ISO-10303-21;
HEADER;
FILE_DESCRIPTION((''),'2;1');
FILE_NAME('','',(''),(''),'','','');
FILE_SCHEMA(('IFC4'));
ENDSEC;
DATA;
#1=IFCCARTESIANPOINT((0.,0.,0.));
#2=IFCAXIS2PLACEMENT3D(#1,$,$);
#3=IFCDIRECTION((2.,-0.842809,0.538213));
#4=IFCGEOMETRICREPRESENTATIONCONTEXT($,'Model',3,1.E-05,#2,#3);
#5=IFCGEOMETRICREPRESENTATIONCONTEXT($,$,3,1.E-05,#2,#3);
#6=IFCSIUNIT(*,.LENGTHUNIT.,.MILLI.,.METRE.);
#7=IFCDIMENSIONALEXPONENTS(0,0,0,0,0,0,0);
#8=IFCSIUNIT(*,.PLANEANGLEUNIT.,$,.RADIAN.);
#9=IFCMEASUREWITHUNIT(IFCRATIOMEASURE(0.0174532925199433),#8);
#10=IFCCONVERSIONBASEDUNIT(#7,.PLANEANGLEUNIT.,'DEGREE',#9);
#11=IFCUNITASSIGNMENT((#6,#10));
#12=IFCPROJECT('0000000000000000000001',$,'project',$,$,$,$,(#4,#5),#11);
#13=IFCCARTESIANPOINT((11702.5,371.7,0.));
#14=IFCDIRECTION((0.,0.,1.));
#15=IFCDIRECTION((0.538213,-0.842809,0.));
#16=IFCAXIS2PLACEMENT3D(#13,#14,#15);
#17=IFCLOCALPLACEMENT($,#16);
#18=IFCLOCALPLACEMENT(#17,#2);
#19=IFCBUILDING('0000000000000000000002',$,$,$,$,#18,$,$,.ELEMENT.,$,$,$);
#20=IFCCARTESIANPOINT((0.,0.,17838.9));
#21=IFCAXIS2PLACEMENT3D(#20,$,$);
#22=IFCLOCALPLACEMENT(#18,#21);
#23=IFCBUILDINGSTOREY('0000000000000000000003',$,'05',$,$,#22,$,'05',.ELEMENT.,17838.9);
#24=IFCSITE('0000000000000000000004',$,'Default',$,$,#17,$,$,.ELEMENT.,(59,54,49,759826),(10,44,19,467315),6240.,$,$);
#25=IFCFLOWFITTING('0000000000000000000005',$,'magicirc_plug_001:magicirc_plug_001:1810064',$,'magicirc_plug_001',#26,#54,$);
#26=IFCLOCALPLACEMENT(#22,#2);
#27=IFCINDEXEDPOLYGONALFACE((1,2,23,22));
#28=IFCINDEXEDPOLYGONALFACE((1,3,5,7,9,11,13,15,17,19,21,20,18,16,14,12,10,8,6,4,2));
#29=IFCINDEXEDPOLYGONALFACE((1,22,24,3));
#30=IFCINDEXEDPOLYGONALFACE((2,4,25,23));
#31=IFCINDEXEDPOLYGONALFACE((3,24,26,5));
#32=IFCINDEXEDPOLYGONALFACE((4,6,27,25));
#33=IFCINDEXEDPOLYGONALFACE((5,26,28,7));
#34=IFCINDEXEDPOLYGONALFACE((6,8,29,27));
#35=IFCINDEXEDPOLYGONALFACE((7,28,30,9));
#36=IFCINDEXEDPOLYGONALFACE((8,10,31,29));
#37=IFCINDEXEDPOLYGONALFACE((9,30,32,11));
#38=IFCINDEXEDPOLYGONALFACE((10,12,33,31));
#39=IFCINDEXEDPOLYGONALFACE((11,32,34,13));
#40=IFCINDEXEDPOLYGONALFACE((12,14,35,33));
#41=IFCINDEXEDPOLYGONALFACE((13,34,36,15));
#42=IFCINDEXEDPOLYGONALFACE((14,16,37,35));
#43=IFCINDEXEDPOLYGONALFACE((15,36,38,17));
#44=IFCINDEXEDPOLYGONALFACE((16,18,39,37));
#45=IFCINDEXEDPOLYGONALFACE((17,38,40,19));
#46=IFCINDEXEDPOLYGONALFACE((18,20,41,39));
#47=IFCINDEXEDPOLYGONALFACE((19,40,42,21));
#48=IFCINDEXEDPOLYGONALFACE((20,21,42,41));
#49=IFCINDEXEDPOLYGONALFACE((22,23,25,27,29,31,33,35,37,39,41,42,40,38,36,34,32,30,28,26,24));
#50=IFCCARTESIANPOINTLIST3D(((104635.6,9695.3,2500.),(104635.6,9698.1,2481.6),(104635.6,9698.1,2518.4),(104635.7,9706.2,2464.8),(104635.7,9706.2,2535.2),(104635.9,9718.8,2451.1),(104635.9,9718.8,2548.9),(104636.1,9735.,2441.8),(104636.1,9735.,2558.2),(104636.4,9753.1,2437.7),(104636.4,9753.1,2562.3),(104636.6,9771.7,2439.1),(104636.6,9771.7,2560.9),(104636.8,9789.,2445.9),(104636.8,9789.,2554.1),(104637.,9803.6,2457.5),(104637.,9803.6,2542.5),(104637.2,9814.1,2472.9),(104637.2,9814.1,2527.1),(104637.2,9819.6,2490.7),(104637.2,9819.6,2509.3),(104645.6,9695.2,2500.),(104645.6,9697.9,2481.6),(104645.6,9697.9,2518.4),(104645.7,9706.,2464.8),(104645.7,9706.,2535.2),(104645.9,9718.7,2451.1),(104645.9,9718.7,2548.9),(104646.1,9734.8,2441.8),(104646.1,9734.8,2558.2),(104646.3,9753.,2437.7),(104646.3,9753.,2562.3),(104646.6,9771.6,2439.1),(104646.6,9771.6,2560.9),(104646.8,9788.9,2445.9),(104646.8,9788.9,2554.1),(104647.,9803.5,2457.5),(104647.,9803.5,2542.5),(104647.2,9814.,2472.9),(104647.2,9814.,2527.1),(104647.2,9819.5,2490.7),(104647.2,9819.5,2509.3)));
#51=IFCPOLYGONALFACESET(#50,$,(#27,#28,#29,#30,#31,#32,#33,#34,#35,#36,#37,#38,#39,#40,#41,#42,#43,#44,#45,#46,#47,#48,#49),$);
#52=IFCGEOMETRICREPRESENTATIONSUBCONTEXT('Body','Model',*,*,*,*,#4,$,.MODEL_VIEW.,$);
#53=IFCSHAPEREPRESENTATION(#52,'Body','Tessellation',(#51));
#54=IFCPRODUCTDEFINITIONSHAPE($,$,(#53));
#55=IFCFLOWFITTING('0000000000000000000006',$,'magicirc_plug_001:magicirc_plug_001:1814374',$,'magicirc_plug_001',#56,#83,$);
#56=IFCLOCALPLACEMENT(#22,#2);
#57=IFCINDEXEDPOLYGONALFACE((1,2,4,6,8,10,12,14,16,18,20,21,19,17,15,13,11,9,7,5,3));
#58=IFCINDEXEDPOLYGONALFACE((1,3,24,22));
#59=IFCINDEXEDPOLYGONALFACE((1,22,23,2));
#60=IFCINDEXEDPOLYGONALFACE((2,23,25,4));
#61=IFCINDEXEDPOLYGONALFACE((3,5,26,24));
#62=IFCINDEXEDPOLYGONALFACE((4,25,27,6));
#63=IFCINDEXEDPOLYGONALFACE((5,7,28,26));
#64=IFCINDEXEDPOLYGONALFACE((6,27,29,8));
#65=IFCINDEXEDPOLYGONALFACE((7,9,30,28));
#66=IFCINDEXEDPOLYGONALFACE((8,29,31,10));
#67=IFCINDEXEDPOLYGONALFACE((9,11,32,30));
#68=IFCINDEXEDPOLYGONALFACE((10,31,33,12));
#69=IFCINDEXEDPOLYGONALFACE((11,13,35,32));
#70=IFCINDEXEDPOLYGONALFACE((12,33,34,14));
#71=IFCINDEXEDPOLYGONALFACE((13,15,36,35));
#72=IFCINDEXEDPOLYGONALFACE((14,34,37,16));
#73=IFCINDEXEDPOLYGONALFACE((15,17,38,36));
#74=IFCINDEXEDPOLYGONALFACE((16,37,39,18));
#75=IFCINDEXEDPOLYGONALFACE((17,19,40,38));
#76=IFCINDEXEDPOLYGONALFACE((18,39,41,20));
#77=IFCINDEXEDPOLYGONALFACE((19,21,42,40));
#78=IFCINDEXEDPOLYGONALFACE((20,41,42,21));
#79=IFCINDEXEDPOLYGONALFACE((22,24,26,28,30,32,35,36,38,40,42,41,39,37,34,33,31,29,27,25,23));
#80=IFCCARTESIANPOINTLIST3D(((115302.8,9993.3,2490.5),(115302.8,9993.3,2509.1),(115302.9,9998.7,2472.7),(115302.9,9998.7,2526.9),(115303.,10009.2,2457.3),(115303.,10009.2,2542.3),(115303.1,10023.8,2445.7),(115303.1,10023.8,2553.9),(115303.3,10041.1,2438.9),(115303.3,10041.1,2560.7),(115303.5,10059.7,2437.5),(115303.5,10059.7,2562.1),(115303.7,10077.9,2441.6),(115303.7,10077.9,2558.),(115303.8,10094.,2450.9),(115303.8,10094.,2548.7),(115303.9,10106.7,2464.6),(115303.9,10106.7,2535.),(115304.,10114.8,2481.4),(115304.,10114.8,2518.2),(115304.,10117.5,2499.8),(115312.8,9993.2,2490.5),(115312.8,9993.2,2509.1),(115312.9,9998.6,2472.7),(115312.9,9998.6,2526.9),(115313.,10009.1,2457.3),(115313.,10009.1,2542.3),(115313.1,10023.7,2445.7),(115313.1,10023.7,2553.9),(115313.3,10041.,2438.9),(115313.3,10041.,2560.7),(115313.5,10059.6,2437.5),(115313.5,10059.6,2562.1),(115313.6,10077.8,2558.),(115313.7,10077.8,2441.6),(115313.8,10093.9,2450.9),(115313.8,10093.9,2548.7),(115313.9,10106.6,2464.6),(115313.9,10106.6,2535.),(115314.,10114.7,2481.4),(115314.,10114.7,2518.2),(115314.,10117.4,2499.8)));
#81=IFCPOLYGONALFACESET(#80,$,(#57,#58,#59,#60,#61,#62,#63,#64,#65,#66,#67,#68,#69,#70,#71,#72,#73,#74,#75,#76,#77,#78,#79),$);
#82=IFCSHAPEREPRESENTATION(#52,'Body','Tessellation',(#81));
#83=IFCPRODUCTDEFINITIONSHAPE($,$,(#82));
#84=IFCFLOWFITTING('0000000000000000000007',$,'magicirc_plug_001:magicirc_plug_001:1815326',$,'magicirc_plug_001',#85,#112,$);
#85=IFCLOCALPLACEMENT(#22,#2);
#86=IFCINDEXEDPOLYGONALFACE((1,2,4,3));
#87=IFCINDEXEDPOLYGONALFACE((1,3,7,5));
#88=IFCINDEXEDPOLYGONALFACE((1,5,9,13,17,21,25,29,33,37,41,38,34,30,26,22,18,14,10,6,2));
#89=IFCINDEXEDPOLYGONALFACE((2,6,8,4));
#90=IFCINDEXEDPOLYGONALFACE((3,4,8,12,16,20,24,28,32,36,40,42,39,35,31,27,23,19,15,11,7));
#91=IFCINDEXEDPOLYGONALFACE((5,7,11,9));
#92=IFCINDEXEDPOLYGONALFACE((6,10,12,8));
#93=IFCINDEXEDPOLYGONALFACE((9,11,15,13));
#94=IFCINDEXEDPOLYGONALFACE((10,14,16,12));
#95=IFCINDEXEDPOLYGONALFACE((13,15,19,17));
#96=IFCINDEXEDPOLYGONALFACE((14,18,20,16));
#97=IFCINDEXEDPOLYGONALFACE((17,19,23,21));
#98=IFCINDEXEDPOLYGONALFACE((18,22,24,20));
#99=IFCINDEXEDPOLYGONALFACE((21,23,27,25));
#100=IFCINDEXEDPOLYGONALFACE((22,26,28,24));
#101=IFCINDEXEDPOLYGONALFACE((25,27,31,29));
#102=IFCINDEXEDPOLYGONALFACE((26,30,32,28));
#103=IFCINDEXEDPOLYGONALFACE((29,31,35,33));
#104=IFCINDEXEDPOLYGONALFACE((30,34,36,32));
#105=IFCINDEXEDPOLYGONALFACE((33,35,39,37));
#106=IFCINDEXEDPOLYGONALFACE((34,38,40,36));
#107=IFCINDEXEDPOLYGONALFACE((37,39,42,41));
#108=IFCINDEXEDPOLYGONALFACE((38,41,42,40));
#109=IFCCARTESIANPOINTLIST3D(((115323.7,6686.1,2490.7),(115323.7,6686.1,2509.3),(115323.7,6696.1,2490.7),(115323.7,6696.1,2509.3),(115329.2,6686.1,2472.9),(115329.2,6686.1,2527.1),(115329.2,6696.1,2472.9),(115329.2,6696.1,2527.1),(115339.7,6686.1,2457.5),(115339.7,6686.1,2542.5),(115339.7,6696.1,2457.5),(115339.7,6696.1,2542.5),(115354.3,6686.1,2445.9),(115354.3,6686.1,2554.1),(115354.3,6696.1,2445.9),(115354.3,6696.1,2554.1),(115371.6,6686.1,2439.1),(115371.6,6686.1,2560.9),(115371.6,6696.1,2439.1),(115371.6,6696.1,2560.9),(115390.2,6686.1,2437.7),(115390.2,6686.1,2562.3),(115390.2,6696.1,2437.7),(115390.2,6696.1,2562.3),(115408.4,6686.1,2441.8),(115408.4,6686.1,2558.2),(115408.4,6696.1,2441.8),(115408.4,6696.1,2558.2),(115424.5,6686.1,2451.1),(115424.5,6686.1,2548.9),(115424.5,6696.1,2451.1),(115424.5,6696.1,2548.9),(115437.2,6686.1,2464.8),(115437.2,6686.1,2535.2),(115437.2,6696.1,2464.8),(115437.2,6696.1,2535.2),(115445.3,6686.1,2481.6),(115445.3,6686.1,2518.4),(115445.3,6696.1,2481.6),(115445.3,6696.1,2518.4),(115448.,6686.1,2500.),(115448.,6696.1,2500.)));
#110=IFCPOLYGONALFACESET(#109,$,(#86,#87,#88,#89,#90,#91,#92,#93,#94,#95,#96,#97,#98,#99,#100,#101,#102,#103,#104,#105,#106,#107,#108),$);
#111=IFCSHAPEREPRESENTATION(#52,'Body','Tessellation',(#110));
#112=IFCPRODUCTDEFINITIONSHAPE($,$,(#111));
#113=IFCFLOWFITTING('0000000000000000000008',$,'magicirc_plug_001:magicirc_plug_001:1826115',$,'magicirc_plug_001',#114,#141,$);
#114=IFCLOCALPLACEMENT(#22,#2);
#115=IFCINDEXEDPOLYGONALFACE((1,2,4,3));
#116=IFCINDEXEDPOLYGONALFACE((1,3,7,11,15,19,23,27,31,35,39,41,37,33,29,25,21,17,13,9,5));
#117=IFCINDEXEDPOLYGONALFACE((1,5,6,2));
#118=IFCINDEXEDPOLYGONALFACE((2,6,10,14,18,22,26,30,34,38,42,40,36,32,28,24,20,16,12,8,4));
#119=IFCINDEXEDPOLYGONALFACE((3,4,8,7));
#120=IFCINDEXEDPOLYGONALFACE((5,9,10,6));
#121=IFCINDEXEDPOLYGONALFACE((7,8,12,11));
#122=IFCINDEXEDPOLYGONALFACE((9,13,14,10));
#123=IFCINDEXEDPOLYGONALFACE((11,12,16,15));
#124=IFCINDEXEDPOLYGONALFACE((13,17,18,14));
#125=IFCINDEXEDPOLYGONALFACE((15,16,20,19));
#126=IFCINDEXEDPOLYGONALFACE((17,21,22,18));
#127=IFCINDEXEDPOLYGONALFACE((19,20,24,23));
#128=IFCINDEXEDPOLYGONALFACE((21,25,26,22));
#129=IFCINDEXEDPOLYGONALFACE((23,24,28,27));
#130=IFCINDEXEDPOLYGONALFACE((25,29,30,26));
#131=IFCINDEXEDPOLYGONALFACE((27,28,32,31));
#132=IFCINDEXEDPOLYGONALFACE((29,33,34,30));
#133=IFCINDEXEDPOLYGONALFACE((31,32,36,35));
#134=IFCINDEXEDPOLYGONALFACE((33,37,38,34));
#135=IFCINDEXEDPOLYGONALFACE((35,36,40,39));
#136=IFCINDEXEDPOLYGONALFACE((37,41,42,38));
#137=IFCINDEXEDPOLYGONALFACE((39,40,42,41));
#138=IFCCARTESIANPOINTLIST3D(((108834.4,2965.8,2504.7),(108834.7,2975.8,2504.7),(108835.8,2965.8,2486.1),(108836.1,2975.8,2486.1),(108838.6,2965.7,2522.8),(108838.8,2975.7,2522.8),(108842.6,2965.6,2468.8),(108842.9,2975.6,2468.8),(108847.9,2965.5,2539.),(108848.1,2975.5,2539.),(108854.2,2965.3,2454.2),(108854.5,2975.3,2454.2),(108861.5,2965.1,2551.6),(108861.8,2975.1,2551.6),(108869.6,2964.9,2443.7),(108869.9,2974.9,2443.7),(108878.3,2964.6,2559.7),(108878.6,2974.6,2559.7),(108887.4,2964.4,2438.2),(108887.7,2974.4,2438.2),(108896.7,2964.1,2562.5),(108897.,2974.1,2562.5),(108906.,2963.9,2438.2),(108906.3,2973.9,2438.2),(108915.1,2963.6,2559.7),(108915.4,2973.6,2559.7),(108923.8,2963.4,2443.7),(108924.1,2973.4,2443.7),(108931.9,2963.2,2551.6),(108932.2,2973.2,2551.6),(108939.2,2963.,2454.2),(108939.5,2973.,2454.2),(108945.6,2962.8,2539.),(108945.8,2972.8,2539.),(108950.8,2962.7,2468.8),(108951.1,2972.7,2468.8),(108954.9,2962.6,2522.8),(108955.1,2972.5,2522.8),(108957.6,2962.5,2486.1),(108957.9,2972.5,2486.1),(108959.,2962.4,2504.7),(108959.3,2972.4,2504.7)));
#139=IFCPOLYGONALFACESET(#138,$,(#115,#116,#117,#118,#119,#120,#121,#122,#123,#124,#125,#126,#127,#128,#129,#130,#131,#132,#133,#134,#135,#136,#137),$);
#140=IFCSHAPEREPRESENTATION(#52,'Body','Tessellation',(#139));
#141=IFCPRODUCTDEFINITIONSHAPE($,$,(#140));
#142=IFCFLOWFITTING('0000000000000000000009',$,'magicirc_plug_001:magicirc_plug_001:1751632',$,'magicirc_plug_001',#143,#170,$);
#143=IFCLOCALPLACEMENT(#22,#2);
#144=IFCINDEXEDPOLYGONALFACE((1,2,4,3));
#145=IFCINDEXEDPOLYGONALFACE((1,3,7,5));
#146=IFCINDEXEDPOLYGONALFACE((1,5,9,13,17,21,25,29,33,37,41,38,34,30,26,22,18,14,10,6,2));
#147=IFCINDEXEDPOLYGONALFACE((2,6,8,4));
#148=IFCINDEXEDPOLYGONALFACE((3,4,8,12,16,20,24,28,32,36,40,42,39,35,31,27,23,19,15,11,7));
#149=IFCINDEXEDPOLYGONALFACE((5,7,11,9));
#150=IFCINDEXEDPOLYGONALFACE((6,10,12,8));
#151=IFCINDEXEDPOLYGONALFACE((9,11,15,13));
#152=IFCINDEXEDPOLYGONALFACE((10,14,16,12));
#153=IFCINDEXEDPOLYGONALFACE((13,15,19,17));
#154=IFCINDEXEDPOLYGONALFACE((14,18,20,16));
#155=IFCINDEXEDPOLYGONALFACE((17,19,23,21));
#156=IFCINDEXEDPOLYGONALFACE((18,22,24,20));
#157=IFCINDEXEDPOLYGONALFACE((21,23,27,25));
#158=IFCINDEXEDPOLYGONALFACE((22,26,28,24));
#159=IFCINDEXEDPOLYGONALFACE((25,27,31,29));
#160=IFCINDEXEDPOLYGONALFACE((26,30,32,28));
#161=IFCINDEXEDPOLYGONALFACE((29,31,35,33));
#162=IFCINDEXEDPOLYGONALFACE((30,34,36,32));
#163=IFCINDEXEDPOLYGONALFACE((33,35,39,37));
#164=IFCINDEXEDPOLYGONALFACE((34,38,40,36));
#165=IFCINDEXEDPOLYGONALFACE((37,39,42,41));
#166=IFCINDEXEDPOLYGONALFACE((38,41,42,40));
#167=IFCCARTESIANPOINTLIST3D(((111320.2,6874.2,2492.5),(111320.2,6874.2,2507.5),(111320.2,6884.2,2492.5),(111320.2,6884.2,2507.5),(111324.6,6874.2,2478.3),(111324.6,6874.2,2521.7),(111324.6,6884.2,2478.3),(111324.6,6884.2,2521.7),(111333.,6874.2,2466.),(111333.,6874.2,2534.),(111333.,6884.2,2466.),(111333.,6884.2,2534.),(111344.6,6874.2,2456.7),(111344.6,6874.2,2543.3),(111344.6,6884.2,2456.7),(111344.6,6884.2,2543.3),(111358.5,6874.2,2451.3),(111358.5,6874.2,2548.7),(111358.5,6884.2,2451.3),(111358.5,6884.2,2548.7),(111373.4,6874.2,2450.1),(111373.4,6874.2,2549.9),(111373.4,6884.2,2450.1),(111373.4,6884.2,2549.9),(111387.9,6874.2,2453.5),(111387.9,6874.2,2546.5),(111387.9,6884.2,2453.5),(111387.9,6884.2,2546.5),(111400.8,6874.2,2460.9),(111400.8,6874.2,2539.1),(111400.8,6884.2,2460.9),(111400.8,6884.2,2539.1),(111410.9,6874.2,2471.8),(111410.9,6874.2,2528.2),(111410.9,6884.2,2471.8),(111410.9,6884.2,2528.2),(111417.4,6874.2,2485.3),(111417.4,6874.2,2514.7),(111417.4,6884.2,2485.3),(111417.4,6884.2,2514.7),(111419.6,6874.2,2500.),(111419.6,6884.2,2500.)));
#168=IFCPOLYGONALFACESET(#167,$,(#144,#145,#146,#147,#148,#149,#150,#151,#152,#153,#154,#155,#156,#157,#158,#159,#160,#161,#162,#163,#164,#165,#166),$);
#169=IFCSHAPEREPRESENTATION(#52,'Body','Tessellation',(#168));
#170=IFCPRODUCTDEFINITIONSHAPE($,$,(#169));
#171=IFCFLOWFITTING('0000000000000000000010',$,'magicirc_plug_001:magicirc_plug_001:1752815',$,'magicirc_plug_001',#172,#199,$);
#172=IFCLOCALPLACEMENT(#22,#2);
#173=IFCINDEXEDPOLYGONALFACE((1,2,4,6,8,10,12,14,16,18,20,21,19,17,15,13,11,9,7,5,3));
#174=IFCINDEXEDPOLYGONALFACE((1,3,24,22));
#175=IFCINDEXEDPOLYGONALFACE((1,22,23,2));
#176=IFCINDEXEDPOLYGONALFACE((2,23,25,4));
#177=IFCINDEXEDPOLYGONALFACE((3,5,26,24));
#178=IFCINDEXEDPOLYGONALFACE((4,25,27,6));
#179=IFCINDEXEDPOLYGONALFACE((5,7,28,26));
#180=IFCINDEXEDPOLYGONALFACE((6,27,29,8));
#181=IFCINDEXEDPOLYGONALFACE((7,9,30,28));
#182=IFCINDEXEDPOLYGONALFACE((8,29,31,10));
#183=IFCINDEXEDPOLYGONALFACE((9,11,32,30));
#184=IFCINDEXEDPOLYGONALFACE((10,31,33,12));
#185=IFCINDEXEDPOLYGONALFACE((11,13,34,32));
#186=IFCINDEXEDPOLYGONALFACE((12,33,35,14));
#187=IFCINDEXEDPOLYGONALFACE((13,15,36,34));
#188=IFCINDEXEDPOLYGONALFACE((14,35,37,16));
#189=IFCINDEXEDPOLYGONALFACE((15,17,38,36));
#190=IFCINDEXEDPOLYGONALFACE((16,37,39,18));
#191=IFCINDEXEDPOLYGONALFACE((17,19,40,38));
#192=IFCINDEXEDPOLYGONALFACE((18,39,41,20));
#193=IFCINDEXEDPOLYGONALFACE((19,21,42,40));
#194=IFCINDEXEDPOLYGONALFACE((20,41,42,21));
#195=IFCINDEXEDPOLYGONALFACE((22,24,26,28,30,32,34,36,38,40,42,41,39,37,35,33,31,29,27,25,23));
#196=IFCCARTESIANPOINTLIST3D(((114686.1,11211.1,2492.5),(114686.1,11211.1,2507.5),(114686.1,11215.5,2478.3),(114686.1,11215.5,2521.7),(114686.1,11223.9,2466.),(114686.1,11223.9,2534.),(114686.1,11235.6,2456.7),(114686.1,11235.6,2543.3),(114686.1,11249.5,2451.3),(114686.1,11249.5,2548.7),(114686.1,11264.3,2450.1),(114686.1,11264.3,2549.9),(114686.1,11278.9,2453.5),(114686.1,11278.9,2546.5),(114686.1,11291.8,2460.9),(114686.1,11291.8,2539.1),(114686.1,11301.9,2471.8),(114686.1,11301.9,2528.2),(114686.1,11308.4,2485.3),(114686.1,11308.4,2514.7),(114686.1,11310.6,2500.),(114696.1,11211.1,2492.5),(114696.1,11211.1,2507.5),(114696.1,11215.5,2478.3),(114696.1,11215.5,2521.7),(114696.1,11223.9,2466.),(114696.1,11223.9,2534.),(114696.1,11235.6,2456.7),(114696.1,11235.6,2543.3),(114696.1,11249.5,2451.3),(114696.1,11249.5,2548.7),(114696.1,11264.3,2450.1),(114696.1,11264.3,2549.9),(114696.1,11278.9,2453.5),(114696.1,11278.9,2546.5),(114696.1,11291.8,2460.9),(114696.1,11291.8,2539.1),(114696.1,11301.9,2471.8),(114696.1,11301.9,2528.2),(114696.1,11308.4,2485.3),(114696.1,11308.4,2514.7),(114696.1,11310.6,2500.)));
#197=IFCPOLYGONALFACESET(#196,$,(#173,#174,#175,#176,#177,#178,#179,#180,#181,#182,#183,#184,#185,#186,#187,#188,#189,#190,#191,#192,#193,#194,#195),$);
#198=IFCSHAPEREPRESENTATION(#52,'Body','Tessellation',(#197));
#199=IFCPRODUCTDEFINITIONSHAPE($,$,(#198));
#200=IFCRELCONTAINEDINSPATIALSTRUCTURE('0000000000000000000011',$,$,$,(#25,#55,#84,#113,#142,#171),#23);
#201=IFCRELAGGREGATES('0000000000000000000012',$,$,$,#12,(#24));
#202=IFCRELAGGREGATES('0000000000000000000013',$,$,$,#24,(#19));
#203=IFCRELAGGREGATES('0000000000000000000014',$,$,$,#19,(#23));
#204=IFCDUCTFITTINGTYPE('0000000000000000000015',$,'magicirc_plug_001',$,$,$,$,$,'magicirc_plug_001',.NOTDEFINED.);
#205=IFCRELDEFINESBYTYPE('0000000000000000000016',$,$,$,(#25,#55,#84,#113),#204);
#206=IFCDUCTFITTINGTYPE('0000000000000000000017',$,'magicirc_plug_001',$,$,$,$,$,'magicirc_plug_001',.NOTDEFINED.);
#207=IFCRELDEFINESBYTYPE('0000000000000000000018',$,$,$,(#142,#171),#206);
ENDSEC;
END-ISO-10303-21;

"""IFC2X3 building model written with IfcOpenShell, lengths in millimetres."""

from ifc_helpers import new_model, entity, si_unit, converted_unit, direction, frame, frame_2d, origin, place, context, subcontext, project, spatial, circle, extrude, source, transform, mapped, type_object, type_shapes, element, save


model = new_model("IFC2X3")

# Units and contexts
model_context = context("Model", 3, precision=1e-05, world=origin(), true_north=direction((2.0, -0.842809, 0.538213)))
context_of_model = context(None, 3, precision=1e-05, world=origin(), true_north=direction((2.0, -0.842809, 0.538213)))
body_context = subcontext(model_context, "Body", "Model", "MODEL_VIEW")
ifc_project = project(units=[si_unit("LENGTHUNIT", "METRE", prefix="MILLI"), converted_unit("PLANEANGLEUNIT", "DEGREE", entity("IfcRatioMeasure", 0.0174532925199433), si_unit("PLANEANGLEUNIT", "RADIAN"), dimensions=[0, 0, 0, 0, 0, 0, 0])], contexts=[model_context, context_of_model])

# Site, building, storey
site_placement = place(None, frame((11702.5, 371.7, 0.0), z_axis=(0.0, 0.0, 1.0), x_axis=(0.538213, -0.842809, 0.0)))
site = spatial("IfcSite", under=ifc_project, at=site_placement, Name="Default", CompositionType="ELEMENT", RefLatitude=(59, 54, 49, 759826), RefLongitude=(10, 44, 19, 467315), RefElevation=6240.0)
building_placement = place(site_placement, origin())
building = spatial("IfcBuilding", under=site, at=building_placement, CompositionType="ELEMENT")
storey_placement = place(building_placement, frame((0.0, 0.0, 17838.9)))
storey = spatial("IfcBuildingStorey", under=building, at=storey_placement, Name="05", LongName="05", CompositionType="ELEMENT", Elevation=17838.9)

# Flow fittings
duct_fitting_type_1 = type_object("IfcDuctFittingType", Name="magicirc_plug_001", ElementType="magicirc_plug_001", PredefinedType="NOTDEFINED")
shared_shape_1 = source(origin(), body_context, "Body", "SweptSolid", [
    extrude(circle(Radius=62.5, at=frame_2d((0.0, 0.0), x_axis=(1.0, 0.0))), frame((0.0, 0.0, 0.0), z_axis=(1.0, 0.0, 0.0), x_axis=(0.0, 1.0, 0.0)), (0.0, 0.0, 1.0), 10.0),
])
type_shapes(duct_fitting_type_1, [shared_shape_1])
for number, where, z_axis, x_axis, name in (
    (1, (104646.4, 9757.7, 2500.0), (0.0, 0.0, 1.0), (-0.999911, 0.013345, 0.0), "magicirc_plug_001:magicirc_plug_001:1810064"),
    (2, (115303.4, 10055.1, 2499.8), (-0.000017, 0.0, 1.0), (0.999952, -0.00981, 0.000017), "magicirc_plug_001:magicirc_plug_001:1814374"),
    (3, (115385.5, 6696.1, 2500.0), (0.0, 0.0, 1.0), (0.0, -1.0, 0.0), "magicirc_plug_001:magicirc_plug_001:1815326"),
    (4, (108897.0, 2974.1, 2500.0), (-0.999628, 0.02726, 0.0), (-0.02726, -0.999628, 0.0), "magicirc_plug_001:magicirc_plug_001:1826115"),
):
    element("IfcFlowFitting", number, at=place(storey_placement, frame(where, z_axis=z_axis, x_axis=x_axis)), inside=storey, type_object=duct_fitting_type_1, Name=name, ObjectType="magicirc_plug_001", context=body_context, shape_type="MappedRepresentation", body=[
        mapped(shared_shape_1, transform((0.0, 0.0, 0.0), scale=1.0)),
    ])

# Flow fittings
duct_fitting_type_2 = type_object("IfcDuctFittingType", Name="magicirc_plug_001", ElementType="magicirc_plug_001", PredefinedType="NOTDEFINED")
shared_shape_2 = source(origin(), body_context, "Body", "SweptSolid", [
    extrude(circle(Radius=50.0, at=frame_2d((0.0, 0.0), x_axis=(1.0, 0.0))), frame((0.0, 0.0, 0.0), z_axis=(1.0, 0.0, 0.0), x_axis=(0.0, 1.0, 0.0)), (0.0, 0.0, 1.0), 10.0),
])
type_shapes(duct_fitting_type_2, [shared_shape_2])
flow_fitting_1_placement = place(storey_placement, frame((111369.6, 6884.2, 2500.0), z_axis=(0.0, 0.0, 1.0), x_axis=(0.0, -1.0, 0.0)))
element("IfcFlowFitting", 5, at=flow_fitting_1_placement, inside=storey, type_object=duct_fitting_type_2, Name="magicirc_plug_001:magicirc_plug_001:1751632", ObjectType="magicirc_plug_001", context=body_context, shape_type="MappedRepresentation", body=[
    mapped(shared_shape_2, transform((0.0, 0.0, 0.0), scale=1.0)),
])
flow_fitting_2_placement = place(storey_placement, frame((114686.1, 11260.6, 2500.0)))
element("IfcFlowFitting", 6, at=flow_fitting_2_placement, inside=storey, type_object=duct_fitting_type_2, Name="magicirc_plug_001:magicirc_plug_001:1752815", ObjectType="magicirc_plug_001", context=body_context, shape_type="MappedRepresentation", body=[
    mapped(shared_shape_2, transform((0.0, 0.0, 0.0), scale=1.0)),
])

save(model, "model.ifc")
